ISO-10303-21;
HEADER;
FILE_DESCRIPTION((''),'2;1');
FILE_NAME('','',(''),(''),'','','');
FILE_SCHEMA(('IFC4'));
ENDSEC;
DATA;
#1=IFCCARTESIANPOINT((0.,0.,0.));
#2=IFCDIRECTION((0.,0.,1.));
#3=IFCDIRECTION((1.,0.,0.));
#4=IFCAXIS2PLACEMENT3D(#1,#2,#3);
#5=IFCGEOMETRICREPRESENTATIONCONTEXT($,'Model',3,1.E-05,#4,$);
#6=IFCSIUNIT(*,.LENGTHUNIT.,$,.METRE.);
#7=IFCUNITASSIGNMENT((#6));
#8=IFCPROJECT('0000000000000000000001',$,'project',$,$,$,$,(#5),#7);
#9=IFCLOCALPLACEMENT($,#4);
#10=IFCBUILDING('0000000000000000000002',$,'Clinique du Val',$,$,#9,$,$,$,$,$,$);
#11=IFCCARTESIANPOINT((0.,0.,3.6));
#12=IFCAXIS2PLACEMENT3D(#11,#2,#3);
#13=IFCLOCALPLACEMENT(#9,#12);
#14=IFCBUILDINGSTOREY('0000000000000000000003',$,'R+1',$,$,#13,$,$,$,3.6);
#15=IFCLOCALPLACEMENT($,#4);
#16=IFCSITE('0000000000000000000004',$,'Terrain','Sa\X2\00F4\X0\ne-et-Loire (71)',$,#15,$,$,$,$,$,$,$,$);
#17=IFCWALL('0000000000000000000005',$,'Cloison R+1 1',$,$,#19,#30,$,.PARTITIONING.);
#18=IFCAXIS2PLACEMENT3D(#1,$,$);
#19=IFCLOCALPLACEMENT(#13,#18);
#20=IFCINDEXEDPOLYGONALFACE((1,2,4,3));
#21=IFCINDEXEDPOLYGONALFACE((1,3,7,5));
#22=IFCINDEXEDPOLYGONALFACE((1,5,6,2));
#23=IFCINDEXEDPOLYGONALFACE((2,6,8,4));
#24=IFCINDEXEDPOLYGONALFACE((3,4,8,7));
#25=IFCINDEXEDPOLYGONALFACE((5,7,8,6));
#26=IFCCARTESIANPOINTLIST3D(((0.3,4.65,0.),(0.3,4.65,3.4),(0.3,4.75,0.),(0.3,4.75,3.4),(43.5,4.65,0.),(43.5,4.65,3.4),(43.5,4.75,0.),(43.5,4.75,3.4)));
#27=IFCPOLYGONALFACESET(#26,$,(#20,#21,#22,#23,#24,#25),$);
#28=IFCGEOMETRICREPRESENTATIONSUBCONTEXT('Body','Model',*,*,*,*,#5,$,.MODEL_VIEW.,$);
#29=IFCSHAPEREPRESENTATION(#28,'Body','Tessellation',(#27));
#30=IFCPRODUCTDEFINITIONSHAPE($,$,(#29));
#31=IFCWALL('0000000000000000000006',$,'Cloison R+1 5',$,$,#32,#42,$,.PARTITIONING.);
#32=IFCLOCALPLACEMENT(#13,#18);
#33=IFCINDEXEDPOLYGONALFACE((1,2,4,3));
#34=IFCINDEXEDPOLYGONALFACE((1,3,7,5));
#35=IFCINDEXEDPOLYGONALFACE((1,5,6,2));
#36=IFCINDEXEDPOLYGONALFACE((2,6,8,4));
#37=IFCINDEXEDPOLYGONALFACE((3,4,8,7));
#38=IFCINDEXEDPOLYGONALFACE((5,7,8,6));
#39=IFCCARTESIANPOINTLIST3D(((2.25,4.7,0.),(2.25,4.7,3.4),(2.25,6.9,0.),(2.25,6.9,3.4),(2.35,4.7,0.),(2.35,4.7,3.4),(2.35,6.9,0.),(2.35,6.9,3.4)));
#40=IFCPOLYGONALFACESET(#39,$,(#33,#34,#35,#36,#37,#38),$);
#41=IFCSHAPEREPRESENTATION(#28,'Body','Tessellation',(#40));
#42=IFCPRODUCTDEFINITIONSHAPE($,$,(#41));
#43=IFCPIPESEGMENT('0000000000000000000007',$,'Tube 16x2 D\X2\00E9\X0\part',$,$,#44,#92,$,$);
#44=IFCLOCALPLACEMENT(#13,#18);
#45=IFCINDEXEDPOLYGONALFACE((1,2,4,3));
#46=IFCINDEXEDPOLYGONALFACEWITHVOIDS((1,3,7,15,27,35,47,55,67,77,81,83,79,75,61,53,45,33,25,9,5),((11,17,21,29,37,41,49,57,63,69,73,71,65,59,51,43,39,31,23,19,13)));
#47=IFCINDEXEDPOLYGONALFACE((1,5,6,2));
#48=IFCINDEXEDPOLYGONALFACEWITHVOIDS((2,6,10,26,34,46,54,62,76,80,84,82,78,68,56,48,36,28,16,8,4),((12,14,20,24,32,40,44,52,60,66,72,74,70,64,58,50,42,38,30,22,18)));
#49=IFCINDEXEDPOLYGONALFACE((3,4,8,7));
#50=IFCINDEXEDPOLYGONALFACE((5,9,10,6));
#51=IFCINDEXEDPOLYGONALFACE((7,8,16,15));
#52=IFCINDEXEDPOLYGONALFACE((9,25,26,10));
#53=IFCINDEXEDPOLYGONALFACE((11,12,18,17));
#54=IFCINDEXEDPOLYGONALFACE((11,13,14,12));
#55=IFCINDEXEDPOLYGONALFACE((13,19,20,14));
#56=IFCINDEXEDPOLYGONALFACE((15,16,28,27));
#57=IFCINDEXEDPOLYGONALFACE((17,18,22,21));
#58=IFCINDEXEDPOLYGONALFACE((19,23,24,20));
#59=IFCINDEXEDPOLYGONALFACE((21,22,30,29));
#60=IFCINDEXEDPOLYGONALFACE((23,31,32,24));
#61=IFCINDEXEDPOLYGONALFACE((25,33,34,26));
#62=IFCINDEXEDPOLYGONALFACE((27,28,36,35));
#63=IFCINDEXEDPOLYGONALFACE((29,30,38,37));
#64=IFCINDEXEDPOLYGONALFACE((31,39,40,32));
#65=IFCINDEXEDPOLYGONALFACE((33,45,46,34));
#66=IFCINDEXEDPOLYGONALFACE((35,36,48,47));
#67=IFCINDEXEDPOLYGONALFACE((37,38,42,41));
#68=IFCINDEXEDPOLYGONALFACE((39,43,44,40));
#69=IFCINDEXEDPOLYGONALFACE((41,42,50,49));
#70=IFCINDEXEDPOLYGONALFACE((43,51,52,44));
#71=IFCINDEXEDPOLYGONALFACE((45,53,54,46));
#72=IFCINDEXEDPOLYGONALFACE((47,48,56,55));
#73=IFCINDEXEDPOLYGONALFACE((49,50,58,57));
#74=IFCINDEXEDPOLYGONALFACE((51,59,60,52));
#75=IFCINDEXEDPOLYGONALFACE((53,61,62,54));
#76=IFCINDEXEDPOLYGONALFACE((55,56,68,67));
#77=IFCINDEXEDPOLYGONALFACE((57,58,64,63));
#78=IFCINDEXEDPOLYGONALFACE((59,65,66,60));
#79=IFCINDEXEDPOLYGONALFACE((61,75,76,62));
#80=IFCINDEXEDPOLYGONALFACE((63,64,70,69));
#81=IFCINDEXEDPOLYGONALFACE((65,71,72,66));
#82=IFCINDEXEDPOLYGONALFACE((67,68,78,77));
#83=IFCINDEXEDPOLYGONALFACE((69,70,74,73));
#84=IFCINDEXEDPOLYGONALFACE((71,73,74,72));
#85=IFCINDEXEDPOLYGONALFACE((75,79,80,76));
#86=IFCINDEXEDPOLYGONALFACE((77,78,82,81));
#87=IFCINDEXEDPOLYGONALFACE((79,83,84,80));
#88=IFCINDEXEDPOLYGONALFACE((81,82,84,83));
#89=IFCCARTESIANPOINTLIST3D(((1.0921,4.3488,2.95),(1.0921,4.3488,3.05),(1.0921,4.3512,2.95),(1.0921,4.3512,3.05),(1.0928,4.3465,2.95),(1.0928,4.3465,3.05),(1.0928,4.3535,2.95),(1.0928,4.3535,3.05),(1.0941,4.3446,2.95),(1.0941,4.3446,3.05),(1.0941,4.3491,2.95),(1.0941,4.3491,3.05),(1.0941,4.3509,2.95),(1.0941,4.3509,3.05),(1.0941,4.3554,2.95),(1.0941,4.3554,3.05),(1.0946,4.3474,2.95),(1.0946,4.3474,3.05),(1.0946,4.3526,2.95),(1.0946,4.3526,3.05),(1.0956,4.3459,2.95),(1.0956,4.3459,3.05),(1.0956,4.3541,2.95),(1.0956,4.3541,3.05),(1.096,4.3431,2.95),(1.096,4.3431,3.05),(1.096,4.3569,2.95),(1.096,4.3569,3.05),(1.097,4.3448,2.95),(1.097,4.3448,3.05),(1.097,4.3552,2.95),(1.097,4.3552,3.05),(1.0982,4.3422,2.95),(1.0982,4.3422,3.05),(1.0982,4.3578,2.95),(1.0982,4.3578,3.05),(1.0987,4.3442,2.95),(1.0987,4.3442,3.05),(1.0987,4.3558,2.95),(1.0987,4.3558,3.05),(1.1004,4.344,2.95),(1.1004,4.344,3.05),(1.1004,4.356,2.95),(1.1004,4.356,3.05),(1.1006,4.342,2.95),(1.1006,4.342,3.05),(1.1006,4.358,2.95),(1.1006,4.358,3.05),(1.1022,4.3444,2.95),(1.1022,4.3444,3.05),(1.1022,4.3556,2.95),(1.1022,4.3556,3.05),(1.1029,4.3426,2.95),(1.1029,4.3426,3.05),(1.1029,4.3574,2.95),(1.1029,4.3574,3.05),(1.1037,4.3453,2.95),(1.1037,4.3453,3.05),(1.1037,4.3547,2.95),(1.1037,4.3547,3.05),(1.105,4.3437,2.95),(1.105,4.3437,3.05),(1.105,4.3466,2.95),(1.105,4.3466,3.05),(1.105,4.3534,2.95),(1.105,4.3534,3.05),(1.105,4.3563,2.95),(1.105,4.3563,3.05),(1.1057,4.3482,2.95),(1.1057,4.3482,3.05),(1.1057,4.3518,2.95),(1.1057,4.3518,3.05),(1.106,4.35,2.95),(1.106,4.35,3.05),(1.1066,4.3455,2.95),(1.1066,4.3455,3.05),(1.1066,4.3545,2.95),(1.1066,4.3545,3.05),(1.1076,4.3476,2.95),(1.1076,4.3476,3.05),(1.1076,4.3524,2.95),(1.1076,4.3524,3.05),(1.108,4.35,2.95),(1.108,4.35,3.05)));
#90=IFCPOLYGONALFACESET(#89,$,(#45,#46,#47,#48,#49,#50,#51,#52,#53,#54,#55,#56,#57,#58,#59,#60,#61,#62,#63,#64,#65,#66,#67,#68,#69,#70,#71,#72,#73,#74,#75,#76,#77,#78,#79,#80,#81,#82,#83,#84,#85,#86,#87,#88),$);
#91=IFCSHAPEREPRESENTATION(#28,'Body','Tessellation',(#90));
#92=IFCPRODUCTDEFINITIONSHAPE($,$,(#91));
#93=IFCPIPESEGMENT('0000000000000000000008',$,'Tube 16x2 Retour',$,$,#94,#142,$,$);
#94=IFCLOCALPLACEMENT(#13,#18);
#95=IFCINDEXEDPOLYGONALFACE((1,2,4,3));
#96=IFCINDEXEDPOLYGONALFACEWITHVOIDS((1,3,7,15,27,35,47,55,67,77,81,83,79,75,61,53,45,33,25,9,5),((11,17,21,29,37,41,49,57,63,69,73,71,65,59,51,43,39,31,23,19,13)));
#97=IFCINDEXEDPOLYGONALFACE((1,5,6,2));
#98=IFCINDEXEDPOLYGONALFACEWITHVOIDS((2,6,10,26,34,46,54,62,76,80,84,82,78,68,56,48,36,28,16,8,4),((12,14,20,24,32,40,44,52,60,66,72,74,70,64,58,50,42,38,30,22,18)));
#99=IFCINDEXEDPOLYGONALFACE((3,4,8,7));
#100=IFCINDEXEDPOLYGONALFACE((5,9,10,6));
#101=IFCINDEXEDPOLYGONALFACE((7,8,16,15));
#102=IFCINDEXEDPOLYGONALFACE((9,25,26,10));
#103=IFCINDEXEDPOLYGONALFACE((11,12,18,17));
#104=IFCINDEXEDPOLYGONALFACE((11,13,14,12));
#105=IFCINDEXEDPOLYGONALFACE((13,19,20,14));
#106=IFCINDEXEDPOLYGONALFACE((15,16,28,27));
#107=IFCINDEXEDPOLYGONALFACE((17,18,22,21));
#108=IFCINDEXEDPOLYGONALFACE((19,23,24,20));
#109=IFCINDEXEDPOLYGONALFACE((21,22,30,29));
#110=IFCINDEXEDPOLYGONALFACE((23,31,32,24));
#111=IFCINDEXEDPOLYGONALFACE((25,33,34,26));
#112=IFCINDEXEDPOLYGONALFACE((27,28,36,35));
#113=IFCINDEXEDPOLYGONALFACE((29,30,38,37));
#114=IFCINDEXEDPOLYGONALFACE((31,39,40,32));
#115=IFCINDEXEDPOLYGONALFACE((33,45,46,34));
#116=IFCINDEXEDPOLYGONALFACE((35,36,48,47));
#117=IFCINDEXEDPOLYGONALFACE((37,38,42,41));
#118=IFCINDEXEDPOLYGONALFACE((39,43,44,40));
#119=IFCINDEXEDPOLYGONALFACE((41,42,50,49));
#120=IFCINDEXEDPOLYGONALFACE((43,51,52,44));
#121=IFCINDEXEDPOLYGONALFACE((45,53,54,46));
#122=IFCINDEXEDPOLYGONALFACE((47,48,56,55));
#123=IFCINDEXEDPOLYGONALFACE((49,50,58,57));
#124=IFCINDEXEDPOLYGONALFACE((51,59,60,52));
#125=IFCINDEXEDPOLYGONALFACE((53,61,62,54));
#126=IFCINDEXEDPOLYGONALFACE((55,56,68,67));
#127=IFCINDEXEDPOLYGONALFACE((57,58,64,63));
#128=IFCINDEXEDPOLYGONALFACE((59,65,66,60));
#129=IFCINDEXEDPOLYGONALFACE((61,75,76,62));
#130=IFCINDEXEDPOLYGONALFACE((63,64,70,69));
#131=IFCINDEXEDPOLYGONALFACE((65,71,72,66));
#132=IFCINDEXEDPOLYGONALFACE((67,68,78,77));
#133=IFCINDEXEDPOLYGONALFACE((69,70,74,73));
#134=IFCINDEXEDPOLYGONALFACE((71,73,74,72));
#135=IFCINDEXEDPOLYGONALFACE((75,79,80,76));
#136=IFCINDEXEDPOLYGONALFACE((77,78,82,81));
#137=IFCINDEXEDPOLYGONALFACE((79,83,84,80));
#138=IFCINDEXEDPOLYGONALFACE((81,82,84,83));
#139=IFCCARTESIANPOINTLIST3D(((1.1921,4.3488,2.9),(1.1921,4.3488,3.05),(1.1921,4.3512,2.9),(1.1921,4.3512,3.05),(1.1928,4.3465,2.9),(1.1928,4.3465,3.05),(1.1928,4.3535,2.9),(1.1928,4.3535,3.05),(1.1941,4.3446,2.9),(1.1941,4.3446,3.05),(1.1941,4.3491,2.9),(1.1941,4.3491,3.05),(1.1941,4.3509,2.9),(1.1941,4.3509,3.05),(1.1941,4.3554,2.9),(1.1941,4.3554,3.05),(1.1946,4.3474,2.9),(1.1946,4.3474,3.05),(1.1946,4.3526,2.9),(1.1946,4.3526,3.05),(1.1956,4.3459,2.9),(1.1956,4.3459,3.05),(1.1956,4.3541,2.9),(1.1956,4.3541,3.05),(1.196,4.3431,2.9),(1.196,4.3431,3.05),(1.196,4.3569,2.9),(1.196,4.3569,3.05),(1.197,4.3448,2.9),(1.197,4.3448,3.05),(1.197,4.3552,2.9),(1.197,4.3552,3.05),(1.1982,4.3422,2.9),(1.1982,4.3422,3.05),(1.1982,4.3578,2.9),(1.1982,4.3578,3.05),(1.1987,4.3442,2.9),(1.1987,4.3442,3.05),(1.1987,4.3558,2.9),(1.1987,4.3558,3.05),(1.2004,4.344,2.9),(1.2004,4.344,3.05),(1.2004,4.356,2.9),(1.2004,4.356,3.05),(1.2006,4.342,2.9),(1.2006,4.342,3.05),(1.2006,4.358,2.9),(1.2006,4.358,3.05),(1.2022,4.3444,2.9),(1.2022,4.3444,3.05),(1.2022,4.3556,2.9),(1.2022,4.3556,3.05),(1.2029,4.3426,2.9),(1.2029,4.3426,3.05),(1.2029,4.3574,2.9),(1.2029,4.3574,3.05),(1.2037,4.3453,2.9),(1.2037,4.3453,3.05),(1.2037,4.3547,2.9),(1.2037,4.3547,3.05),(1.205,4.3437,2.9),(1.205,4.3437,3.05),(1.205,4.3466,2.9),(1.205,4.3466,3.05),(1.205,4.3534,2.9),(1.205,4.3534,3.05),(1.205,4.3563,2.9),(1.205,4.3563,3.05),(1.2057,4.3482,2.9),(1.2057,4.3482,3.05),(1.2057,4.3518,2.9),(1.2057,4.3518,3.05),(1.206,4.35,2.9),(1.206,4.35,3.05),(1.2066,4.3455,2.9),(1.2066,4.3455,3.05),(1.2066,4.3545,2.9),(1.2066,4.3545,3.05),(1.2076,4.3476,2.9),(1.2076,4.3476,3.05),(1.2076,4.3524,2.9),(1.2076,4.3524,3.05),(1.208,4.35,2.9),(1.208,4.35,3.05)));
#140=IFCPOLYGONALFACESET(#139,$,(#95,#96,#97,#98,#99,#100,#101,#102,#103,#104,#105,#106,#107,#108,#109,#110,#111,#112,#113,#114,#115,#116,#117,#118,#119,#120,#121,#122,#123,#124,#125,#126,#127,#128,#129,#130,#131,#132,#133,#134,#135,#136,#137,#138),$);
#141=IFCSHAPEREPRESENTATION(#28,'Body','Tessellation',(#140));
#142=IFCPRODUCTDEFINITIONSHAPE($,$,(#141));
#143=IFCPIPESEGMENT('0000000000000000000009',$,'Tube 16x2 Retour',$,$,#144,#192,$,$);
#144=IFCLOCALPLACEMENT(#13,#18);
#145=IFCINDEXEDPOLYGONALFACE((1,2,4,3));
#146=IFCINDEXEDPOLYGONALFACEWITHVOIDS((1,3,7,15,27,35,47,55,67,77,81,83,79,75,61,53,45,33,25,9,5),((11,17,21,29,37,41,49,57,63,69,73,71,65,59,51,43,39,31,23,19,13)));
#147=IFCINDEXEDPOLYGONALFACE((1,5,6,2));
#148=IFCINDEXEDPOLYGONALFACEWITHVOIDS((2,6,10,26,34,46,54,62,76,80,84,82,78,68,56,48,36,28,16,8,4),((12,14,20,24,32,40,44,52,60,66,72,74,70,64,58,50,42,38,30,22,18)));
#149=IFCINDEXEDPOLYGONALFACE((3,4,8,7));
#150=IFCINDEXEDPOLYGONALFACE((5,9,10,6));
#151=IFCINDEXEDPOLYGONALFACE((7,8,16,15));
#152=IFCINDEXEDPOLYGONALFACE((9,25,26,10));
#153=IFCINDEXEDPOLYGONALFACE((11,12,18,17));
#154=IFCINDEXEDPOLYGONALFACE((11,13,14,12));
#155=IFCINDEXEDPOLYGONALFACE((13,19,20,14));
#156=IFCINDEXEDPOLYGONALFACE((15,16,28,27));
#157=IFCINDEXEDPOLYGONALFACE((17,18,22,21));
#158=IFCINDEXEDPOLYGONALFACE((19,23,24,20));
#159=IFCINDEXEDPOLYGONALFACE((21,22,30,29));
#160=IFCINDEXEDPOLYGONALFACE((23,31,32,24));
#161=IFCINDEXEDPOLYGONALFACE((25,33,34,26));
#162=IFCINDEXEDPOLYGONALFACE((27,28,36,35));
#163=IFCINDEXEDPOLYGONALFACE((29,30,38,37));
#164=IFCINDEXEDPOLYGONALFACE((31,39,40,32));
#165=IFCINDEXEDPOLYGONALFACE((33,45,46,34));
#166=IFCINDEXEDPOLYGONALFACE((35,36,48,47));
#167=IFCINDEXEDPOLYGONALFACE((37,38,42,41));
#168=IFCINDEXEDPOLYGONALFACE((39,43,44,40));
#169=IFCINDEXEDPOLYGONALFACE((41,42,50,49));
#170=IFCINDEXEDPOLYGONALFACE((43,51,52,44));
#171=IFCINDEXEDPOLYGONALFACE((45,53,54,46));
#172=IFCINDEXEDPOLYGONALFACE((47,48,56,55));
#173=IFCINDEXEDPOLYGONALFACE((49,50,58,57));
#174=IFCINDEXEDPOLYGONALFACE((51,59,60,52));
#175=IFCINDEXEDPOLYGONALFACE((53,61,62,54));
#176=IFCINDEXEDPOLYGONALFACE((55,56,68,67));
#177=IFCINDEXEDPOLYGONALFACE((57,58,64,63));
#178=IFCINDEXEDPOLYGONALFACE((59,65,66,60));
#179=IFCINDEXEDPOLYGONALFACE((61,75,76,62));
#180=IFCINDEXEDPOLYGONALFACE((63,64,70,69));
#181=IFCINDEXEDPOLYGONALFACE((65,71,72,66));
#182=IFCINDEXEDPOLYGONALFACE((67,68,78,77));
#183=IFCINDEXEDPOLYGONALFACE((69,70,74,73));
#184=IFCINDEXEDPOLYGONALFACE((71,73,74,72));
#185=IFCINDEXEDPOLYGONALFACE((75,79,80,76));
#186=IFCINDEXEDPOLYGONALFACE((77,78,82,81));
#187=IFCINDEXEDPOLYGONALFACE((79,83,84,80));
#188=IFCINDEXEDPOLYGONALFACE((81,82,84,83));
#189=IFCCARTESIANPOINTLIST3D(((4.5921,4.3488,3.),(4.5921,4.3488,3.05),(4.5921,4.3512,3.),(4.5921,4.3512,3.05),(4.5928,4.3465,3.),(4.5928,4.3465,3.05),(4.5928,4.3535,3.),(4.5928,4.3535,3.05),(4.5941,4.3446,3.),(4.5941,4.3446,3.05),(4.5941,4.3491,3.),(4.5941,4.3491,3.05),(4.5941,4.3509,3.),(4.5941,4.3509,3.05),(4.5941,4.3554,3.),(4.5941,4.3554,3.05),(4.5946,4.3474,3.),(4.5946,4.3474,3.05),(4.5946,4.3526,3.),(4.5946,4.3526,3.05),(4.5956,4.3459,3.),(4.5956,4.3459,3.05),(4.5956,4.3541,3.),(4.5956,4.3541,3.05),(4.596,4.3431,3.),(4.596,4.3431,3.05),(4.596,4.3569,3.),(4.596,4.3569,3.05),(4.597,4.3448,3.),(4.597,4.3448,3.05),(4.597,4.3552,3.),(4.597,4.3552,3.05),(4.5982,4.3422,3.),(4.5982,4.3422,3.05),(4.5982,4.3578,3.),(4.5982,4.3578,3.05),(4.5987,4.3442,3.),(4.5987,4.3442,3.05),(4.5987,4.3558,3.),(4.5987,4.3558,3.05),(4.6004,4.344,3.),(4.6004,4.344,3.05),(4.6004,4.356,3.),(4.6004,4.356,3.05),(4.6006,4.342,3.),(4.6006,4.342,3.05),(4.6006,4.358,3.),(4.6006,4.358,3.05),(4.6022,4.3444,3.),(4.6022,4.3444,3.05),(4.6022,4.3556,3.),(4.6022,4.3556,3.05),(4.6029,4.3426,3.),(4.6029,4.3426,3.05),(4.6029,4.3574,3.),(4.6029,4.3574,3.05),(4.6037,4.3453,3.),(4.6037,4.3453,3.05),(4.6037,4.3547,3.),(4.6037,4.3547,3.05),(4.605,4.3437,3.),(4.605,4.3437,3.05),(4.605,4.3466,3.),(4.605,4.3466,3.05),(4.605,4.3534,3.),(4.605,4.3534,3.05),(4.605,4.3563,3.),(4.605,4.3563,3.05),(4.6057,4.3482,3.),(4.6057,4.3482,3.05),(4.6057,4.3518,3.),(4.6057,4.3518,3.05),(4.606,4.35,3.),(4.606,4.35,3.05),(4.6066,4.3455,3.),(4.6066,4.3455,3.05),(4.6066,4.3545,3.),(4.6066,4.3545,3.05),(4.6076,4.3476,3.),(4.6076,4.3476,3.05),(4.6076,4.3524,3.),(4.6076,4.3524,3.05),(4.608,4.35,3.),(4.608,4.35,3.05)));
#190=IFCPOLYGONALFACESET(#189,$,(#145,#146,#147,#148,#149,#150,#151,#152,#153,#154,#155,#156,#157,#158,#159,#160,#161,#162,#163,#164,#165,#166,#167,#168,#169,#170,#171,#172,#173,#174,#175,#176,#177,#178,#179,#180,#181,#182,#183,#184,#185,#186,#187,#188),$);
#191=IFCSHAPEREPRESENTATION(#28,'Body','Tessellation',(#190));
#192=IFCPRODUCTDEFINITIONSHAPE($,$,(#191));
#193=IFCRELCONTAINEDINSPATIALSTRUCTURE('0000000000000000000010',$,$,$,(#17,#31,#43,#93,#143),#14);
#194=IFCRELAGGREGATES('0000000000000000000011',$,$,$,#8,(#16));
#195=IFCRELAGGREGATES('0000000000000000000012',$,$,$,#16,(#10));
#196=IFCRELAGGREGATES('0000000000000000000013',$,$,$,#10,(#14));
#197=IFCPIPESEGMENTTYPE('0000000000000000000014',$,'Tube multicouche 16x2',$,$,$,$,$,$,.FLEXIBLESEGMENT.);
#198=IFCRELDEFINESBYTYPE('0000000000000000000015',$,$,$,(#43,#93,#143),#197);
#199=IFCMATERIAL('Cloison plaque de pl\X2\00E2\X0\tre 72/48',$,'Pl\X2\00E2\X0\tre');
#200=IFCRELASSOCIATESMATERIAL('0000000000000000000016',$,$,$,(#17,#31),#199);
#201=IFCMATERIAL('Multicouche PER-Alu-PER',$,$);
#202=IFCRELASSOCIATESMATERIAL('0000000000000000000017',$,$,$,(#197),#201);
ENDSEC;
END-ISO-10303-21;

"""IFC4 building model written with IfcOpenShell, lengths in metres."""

from ifc_helpers import new_model, si_unit, frame, frame_2d, origin_with_axes, place, context, subcontext, project, spatial, rectangle, hollow_circle, extrude, material, type_object, element, save


model = new_model("IFC4")

# Units and contexts
model_context = context("Model", 3, precision=1e-05, world=origin_with_axes())
body_context = subcontext(model_context, "Body", "Model", "MODEL_VIEW")
ifc_project = project(units=[si_unit("LENGTHUNIT", "METRE")], contexts=[model_context])

# Site, building, storey
site_placement = place(None, origin_with_axes())
site = spatial("IfcSite", under=ifc_project, at=site_placement, Name="Terrain", Description="Saône-et-Loire (71)")
building_placement = place(None, origin_with_axes())
building = spatial("IfcBuilding", under=site, at=building_placement, Name="Clinique du Val")
storey_placement = place(building_placement, frame((0.0, 0.0, 3.6), z_axis=(0.0, 0.0, 1.0), x_axis=(1.0, 0.0, 0.0)))
storey = spatial("IfcBuildingStorey", under=building, at=storey_placement, Name="R+1", Elevation=3.6)

# Walls
ifc_material_1 = material(Name="Cloison plaque de plâtre 72/48", Category="Plâtre")
wall_1_placement = place(storey_placement, frame((0.3, 4.65, 0.0), z_axis=(0.0, 0.0, 1.0), x_axis=(1.0, 0.0, 0.0)))
element("IfcWall", 1, at=wall_1_placement, inside=storey, material=ifc_material_1, Name="Cloison R+1 1", PredefinedType="PARTITIONING", context=body_context, shape_type="SweptSolid", body=[
    extrude(rectangle(XDim=43.2, YDim=0.1, at=frame_2d((21.6, 0.05))), origin_with_axes(), (0.0, 0.0, 1.0), 3.4),
])
wall_2_placement = place(storey_placement, frame((2.25, 4.7, 0.0), z_axis=(0.0, 0.0, 1.0), x_axis=(1.0, 0.0, 0.0)))
element("IfcWall", 2, at=wall_2_placement, inside=storey, material=ifc_material_1, Name="Cloison R+1 5", PredefinedType="PARTITIONING", context=body_context, shape_type="SweptSolid", body=[
    extrude(rectangle(XDim=0.1, YDim=2.2, at=frame_2d((0.05, 1.1))), origin_with_axes(), (0.0, 0.0, 1.0), 3.4),
])

# Pipe segments
ifc_material_2 = material(Name="Multicouche PER-Alu-PER")
pipe_segment_type = type_object("IfcPipeSegmentType", Name="Tube multicouche 16x2", PredefinedType="FLEXIBLESEGMENT", material=ifc_material_2)
pipe_segment_1_placement = place(storey_placement, frame((1.1, 4.35, 2.95), z_axis=(0.0, 0.0, 1.0), x_axis=(1.0, 0.0, 0.0)))
element("IfcPipeSegment", 3, at=pipe_segment_1_placement, inside=storey, type_object=pipe_segment_type, Name="Tube 16x2 Départ", context=body_context, shape_type="SweptSolid", body=[
    extrude(hollow_circle(Radius=0.008, WallThickness=0.002), origin_with_axes(), (0.0, 0.0, 1.0), 0.1),
])
pipe_segment_2_placement = place(storey_placement, frame((1.2, 4.35, 2.9), z_axis=(0.0, 0.0, 1.0), x_axis=(1.0, 0.0, 0.0)))
element("IfcPipeSegment", 4, at=pipe_segment_2_placement, inside=storey, type_object=pipe_segment_type, Name="Tube 16x2 Retour", context=body_context, shape_type="SweptSolid", body=[
    extrude(hollow_circle(Radius=0.008, WallThickness=0.002), origin_with_axes(), (0.0, 0.0, 1.0), 0.15),
])
pipe_segment_3_placement = place(storey_placement, frame((4.6, 4.35, 3.0), z_axis=(0.0, 0.0, 1.0), x_axis=(1.0, 0.0, 0.0)))
element("IfcPipeSegment", 5, at=pipe_segment_3_placement, inside=storey, type_object=pipe_segment_type, Name="Tube 16x2 Retour", context=body_context, shape_type="SweptSolid", body=[
    extrude(hollow_circle(Radius=0.008, WallThickness=0.002), origin_with_axes(), (0.0, 0.0, 1.0), 0.05),
])

save(model, "model.ifc")
